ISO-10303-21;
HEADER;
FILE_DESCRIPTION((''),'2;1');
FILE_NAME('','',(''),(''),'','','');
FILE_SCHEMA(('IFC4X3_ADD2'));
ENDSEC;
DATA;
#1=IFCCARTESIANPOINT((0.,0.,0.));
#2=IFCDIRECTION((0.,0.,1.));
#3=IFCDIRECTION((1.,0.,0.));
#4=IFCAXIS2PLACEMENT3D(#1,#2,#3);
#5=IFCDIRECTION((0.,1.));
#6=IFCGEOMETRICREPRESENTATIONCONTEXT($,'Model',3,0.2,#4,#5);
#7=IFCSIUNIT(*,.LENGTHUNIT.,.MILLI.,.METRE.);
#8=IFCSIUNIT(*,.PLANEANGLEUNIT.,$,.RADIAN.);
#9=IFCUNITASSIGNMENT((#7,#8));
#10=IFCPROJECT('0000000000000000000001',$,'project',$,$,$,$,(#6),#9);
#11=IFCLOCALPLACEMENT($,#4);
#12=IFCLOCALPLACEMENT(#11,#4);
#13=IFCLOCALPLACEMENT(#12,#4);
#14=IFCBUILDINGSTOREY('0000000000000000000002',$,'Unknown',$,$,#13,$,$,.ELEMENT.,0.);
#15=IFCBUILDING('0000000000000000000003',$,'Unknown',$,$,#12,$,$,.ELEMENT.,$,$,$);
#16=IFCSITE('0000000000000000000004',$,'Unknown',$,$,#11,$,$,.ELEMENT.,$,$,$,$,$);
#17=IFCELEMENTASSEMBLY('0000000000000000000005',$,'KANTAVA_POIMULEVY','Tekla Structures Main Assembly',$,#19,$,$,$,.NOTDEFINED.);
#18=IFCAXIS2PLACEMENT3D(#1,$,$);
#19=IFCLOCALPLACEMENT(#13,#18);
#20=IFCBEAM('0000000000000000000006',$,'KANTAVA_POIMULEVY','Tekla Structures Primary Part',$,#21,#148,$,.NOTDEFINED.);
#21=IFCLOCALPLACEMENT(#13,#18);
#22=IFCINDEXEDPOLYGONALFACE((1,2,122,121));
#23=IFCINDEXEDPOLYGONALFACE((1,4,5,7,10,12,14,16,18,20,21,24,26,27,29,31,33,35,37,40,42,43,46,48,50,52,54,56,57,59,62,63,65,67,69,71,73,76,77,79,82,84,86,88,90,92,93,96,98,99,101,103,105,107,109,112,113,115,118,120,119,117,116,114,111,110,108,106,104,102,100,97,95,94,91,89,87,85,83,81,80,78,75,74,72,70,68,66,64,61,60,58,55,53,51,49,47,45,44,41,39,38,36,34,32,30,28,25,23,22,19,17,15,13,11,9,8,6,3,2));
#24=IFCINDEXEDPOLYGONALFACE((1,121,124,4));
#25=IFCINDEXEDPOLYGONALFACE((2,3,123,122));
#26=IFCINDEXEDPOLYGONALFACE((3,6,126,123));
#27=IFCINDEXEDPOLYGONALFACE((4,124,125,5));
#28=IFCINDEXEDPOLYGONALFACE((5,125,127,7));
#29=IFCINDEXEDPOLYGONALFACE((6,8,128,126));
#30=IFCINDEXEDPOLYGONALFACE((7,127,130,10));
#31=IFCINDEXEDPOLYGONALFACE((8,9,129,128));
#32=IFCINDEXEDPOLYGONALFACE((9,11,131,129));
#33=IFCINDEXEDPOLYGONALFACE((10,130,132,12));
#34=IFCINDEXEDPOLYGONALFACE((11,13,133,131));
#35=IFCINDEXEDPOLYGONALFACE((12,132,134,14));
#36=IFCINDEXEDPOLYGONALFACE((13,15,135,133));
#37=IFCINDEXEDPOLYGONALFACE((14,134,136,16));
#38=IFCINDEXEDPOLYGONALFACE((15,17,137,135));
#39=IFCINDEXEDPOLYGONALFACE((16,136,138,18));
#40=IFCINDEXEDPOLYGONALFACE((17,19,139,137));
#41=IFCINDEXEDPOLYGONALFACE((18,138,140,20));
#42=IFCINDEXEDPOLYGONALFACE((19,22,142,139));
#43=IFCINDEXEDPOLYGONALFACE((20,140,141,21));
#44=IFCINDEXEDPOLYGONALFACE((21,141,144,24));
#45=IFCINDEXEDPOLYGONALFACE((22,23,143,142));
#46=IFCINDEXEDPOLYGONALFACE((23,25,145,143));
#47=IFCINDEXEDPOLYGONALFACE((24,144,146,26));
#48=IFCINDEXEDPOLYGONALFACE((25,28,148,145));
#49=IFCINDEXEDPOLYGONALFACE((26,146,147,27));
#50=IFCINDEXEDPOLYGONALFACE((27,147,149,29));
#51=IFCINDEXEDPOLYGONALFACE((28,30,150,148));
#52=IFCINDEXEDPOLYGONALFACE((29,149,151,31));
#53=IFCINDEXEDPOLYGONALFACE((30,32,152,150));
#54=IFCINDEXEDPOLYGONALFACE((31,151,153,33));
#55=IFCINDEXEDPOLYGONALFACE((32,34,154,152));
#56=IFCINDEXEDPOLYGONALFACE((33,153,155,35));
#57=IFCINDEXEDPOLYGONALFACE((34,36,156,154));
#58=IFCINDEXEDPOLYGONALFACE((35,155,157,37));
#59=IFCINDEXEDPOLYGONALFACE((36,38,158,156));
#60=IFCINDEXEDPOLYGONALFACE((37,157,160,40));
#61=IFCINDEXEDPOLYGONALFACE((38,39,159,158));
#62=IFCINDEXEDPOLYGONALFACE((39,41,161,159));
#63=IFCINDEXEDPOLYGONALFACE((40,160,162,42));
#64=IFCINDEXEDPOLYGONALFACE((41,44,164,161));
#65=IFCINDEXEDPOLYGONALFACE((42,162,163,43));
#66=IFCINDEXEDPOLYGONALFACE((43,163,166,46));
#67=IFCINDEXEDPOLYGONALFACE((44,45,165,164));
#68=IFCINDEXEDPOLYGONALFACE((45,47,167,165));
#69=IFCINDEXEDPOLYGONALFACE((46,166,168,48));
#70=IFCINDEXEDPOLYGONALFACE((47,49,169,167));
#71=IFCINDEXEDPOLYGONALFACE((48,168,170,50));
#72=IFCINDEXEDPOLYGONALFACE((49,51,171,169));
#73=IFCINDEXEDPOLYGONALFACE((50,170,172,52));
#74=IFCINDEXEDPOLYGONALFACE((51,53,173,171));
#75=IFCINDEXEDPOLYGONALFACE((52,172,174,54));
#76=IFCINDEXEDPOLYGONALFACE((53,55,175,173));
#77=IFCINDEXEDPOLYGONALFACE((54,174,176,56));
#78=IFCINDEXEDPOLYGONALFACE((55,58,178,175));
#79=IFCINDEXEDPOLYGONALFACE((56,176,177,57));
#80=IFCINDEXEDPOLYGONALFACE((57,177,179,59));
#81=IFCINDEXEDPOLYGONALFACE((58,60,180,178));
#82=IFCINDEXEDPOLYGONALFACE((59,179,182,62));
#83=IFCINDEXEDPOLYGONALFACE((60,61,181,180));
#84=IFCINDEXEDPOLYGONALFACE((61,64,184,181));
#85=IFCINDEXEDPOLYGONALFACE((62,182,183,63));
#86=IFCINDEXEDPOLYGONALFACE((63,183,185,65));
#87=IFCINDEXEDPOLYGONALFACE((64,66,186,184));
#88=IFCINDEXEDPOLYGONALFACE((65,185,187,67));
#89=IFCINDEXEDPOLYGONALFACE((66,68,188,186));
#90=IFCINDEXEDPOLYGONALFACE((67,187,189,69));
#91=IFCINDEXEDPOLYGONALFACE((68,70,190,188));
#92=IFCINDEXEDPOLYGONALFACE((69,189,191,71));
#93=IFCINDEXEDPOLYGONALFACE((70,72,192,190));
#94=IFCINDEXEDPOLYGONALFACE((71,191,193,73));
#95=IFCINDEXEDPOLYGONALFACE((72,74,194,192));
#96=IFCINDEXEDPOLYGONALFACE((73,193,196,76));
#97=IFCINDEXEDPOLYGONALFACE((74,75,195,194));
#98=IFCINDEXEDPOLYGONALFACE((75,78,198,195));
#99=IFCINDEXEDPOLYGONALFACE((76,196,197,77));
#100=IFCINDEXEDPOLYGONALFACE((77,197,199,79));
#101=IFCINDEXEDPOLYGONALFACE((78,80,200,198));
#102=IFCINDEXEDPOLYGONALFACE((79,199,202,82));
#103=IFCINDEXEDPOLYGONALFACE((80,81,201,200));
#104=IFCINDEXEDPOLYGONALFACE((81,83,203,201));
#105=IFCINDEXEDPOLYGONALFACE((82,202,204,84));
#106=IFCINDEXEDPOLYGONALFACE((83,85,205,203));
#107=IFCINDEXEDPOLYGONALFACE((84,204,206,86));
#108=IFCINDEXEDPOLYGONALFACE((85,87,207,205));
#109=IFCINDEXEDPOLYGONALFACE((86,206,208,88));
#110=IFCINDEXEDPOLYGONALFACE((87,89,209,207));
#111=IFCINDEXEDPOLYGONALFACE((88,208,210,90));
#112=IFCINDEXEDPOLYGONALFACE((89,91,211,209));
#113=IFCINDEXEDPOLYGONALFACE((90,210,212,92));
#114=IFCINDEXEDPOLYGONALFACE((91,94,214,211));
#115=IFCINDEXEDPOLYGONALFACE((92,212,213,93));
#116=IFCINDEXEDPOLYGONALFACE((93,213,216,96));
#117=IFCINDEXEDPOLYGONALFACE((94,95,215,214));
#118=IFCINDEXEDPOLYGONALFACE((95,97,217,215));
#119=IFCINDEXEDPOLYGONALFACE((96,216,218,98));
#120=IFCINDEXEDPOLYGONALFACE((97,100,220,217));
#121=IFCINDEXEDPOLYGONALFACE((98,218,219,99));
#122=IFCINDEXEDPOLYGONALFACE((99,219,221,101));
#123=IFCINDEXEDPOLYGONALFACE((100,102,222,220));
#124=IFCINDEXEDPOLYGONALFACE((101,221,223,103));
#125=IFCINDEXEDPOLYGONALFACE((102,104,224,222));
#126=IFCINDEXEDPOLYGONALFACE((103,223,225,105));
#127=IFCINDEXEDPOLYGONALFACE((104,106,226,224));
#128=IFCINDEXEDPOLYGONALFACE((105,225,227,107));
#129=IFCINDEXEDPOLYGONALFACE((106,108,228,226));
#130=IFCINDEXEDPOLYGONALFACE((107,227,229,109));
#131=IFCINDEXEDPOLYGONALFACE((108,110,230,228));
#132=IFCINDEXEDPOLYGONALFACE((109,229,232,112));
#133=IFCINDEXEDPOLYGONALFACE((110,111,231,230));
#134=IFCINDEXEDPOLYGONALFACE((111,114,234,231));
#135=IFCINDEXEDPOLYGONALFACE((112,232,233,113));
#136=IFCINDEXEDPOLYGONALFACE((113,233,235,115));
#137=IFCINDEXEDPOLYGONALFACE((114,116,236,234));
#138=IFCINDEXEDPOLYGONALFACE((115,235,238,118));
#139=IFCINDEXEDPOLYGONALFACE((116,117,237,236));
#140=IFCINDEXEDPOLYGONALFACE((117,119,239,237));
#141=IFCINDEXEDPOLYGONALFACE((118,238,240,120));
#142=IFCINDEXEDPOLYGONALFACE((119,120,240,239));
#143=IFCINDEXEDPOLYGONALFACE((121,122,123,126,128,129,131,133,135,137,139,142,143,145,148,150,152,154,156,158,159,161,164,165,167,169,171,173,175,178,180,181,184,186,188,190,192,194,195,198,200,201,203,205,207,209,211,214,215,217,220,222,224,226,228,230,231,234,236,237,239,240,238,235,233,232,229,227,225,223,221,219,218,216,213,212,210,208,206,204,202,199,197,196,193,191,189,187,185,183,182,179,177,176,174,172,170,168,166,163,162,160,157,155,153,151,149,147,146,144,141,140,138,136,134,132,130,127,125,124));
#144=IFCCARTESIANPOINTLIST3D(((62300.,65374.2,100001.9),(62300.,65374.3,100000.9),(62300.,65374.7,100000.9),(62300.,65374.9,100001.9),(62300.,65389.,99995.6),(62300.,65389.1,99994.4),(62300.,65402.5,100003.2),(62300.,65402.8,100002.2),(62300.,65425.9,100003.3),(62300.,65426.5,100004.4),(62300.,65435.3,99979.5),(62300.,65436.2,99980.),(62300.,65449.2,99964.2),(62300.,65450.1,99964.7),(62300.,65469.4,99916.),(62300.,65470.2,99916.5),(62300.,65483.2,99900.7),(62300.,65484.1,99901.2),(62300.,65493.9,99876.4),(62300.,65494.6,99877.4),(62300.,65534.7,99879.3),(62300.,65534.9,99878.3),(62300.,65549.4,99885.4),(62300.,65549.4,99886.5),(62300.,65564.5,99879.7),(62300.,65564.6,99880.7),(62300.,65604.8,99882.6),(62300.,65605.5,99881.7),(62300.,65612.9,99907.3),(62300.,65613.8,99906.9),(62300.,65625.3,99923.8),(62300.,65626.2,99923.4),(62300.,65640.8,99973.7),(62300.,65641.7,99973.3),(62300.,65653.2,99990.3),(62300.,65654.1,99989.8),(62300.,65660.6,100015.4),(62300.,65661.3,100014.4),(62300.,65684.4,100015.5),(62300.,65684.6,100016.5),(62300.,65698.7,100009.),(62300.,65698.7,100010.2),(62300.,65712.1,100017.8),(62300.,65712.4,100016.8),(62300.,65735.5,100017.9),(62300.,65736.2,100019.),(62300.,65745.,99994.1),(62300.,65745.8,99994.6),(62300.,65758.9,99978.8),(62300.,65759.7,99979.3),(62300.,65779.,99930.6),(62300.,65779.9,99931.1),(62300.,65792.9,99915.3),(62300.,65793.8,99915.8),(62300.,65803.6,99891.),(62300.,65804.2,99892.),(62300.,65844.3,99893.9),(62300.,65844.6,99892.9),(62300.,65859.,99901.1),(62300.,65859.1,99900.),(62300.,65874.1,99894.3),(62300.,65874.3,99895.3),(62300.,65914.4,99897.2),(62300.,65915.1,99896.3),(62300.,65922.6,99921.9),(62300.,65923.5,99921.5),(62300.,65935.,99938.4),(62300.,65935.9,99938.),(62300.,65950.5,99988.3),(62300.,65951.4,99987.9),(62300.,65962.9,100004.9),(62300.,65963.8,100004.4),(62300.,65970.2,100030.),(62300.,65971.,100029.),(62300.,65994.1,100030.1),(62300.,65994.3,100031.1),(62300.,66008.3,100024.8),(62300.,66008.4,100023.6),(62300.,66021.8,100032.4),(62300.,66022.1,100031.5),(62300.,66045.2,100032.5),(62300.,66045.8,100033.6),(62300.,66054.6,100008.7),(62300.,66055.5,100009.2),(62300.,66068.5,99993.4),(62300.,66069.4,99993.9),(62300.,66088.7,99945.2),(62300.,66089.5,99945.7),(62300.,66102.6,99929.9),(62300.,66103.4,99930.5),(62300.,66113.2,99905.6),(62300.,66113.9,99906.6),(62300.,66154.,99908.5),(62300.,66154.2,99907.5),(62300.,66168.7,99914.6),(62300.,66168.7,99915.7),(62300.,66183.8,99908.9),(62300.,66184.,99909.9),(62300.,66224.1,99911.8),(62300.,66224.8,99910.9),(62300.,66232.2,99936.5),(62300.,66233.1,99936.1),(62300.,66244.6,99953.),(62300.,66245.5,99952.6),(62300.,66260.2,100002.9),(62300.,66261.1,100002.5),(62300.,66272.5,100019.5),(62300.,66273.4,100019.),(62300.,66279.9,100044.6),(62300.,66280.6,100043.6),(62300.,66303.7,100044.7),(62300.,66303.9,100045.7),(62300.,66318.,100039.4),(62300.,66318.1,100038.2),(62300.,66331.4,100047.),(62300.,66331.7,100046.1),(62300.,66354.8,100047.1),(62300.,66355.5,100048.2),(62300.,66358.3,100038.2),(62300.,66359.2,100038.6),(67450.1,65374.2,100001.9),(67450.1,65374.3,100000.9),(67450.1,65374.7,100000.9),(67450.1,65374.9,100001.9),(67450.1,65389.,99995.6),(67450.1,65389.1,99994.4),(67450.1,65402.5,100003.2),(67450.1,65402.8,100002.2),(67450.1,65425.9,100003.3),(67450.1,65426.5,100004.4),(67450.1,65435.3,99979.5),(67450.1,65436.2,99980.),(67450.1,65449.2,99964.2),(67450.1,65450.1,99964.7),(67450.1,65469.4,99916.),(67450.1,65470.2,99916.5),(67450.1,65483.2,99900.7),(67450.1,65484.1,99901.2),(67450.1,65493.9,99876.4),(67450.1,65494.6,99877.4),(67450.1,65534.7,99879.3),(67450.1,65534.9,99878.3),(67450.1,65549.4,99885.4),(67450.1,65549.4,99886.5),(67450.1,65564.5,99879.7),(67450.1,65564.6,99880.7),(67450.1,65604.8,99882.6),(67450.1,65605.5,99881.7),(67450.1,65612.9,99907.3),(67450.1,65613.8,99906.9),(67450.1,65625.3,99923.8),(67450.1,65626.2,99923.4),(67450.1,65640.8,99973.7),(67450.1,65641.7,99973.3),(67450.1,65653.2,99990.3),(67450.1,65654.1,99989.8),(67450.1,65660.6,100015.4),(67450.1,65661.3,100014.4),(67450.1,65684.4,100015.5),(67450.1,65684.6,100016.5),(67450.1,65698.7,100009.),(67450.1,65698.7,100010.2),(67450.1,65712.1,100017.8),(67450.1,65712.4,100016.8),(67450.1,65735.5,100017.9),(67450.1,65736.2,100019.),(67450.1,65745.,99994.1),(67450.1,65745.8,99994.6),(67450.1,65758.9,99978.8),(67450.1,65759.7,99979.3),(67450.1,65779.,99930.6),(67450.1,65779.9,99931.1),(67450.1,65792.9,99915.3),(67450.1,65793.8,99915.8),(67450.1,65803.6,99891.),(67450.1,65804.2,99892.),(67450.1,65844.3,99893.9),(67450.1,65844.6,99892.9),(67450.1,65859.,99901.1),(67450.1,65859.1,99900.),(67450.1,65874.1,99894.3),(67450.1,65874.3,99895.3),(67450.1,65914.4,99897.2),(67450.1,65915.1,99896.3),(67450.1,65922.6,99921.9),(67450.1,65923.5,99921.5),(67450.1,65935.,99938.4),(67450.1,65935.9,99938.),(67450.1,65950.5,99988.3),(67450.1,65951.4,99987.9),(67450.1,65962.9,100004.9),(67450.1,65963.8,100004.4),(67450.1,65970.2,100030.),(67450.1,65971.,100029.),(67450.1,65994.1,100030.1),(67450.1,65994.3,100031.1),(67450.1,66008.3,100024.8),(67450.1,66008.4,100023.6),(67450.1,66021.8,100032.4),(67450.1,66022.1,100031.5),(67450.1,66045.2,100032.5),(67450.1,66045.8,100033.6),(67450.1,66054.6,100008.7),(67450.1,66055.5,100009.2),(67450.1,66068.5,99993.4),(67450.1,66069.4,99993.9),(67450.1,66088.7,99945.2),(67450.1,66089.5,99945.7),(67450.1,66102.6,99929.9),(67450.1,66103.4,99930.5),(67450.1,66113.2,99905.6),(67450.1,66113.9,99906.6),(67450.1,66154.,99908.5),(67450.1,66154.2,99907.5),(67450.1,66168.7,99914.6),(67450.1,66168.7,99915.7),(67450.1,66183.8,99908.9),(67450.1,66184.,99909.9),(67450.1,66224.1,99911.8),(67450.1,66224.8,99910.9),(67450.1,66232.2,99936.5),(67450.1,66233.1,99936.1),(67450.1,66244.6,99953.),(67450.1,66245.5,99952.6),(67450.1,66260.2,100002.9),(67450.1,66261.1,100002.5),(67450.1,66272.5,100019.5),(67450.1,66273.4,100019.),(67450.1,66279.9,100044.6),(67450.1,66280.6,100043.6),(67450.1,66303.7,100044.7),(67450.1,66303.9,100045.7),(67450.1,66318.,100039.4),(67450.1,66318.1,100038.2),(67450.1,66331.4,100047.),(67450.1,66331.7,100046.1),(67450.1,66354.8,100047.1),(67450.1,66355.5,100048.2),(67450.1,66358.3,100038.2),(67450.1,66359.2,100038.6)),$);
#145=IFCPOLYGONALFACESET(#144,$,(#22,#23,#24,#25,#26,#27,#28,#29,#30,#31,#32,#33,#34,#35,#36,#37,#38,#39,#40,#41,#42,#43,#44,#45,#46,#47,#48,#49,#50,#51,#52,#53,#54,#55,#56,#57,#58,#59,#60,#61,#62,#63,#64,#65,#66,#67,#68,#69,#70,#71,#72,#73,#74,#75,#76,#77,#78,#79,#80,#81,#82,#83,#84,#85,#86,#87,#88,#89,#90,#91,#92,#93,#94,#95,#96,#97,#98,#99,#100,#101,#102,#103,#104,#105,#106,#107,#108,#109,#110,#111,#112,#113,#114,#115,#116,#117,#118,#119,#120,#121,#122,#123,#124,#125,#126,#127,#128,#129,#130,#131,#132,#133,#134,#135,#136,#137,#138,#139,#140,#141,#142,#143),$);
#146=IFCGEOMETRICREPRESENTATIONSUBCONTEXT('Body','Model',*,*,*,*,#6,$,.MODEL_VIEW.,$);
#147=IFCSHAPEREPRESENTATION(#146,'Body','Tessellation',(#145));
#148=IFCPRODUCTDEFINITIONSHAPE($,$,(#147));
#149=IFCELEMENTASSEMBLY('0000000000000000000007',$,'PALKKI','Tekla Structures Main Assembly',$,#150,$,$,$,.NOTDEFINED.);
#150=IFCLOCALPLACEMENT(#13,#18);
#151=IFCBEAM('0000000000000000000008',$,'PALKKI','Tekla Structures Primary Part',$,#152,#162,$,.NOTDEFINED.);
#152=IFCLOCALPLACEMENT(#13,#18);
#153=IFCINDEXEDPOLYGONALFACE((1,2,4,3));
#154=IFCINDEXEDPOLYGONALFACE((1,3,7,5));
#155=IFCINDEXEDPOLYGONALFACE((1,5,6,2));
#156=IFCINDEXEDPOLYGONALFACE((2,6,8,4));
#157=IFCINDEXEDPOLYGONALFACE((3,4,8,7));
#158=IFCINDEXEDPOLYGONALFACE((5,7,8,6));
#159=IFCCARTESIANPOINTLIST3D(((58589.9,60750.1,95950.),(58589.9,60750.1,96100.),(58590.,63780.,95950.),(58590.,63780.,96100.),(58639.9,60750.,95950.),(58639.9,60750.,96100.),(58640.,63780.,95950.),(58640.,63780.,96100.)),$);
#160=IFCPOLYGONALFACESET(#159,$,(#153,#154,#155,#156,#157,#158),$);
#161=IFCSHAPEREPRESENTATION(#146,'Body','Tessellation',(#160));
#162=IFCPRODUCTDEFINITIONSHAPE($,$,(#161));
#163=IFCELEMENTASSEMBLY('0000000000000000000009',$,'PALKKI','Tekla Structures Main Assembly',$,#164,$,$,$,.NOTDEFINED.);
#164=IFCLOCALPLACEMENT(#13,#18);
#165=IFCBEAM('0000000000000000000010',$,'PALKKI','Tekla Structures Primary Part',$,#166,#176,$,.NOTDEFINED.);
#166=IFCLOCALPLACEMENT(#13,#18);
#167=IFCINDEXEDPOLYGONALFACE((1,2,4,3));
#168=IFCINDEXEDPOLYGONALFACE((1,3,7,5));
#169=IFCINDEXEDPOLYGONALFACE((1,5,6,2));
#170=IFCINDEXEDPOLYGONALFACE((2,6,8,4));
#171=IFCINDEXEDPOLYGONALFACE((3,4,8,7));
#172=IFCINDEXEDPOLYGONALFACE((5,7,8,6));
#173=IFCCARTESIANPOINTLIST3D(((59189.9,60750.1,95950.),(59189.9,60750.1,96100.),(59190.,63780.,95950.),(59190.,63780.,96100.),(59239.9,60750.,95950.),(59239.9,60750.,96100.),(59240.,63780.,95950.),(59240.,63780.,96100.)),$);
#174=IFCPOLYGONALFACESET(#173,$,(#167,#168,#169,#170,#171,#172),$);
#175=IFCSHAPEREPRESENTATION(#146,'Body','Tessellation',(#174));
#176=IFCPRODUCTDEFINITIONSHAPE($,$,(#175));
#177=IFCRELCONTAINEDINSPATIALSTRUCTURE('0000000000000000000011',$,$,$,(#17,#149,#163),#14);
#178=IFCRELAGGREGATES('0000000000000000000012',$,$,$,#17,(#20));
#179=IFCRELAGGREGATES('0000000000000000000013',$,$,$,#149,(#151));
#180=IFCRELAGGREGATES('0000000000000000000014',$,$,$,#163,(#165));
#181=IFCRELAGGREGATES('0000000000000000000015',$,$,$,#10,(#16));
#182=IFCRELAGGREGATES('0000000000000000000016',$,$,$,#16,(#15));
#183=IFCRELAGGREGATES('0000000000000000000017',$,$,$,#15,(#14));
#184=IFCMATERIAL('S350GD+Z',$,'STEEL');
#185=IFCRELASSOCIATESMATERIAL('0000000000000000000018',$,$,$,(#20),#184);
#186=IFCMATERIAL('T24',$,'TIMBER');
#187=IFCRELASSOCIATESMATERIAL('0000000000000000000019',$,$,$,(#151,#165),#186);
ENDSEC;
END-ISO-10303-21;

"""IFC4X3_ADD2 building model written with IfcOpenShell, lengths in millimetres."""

from ifc_helpers import new_model, si_unit, direction, frame, origin_with_axes, place, context, subcontext, project, spatial, line, indexed_curve, outline, extrude, material, element, aggregate, save


model = new_model("IFC4X3_ADD2")

# Units and contexts
model_context = context("Model", 3, precision=0.2, world=origin_with_axes(), true_north=direction((0.0, 1.0)))
body_context = subcontext(model_context, "Body", "Model", "MODEL_VIEW")
ifc_project = project(units=[si_unit("LENGTHUNIT", "METRE", prefix="MILLI"), si_unit("PLANEANGLEUNIT", "RADIAN")], contexts=[model_context])

# Site, building, storey
site_placement = place(None, origin_with_axes())
site = spatial("IfcSite", under=ifc_project, at=site_placement, Name="Unknown", CompositionType="ELEMENT")
building_placement = place(site_placement, origin_with_axes())
building = spatial("IfcBuilding", under=site, at=building_placement, Name="Unknown", CompositionType="ELEMENT")
storey_placement = place(building_placement, origin_with_axes())
storey = spatial("IfcBuildingStorey", under=building, at=storey_placement, Name="Unknown", CompositionType="ELEMENT", Elevation=0.0)

# Element assemblies, beams
ifc_material_1 = material(Name="S350GD+Z", Category="STEEL")
assembly_1_placement = place(storey_placement, frame((62300.0, 65856.3, 99959.1), z_axis=(0.0, -0.99889, -0.047106), x_axis=(1.0, 0.0, 0.0)))
assembly_1 = element("IfcElementAssembly", 1, at=assembly_1_placement, inside=storey, Name="KANTAVA_POIMULEVY", Description="Tekla Structures Main Assembly", PredefinedType="NOTDEFINED")
beam_1_placement = place(assembly_1_placement, origin_with_axes())
beam_1 = element("IfcBeam", 2, at=beam_1_placement, material=ifc_material_1, Name="KANTAVA_POIMULEVY", Description="Tekla Structures Primary Part", PredefinedType="NOTDEFINED", context=body_context, shape_type="SolidModel", body=[
    extrude(outline(indexed_curve([(479.5, 65.5), (478.8, 65.5), (465.0, 58.5), (451.2, 65.5), (427.1, 65.5), (418.6, 40.7), (405.5, 24.8), (387.6, -24.3), (374.5, -40.2), (365.1, -64.5), (325.0, -64.5), (310.0, -58.1), (295.0, -64.5), (254.8, -64.5), (245.5, -40.2), (232.4, -24.3), (214.5, 24.8), (201.4, 40.7), (192.9, 65.5), (168.8, 65.5), (155.0, 58.5), (141.2, 65.5), (117.1, 65.5), (108.6, 40.7), (95.5, 24.8), (77.6, -24.3), (64.5, -40.2), (55.1, -64.5), (15.0, -64.5), (0.0, -58.1), (-15.0, -64.5), (-55.2, -64.5), (-64.5, -40.2), (-77.6, -24.3), (-95.5, 24.8), (-108.6, 40.7), (-117.2, 65.5), (-141.2, 65.5), (-155.0, 58.5), (-168.8, 65.5), (-192.9, 65.5), (-201.4, 40.7), (-214.5, 24.8), (-232.4, -24.3), (-245.5, -40.2), (-254.9, -64.5), (-295.0, -64.5), (-310.0, -58.1), (-325.0, -64.5), (-365.2, -64.5), (-374.5, -40.2), (-387.6, -24.3), (-405.5, 24.8), (-418.6, 40.7), (-427.1, 65.5), (-451.2, 65.5), (-465.0, 58.5), (-478.8, 65.5), (-502.9, 65.5), (-506.2, 55.7), (-505.2, 55.4), (-502.1, 64.5), (-479.0, 64.5), (-465.0, 57.3), (-451.0, 64.5), (-427.9, 64.5), (-419.5, 40.2), (-406.4, 24.3), (-388.5, -24.8), (-375.4, -40.7), (-365.9, -65.5), (-324.8, -65.5), (-310.0, -59.1), (-295.2, -65.5), (-254.2, -65.5), (-244.6, -40.7), (-231.5, -24.8), (-213.6, 24.3), (-200.5, 40.2), (-192.1, 64.5), (-169.0, 64.5), (-155.0, 57.3), (-141.0, 64.5), (-117.9, 64.5), (-109.5, 40.2), (-96.4, 24.3), (-78.5, -24.8), (-65.4, -40.7), (-55.9, -65.5), (-14.8, -65.5), (0.0, -59.1), (14.8, -65.5), (55.8, -65.5), (65.4, -40.7), (78.5, -24.8), (96.4, 24.3), (109.5, 40.2), (117.8, 64.5), (141.0, 64.5), (155.0, 57.3), (169.0, 64.5), (192.1, 64.5), (200.5, 40.2), (213.6, 24.3), (231.5, -24.8), (244.6, -40.7), (254.1, -65.5), (295.2, -65.5), (310.0, -59.1), (324.8, -65.5), (365.8, -65.5), (375.4, -40.7), (388.5, -24.8), (406.4, 24.3), (419.5, 40.2), (427.9, 64.5), (451.0, 64.5), (465.0, 57.3), (479.0, 64.5), (479.5, 64.5)], segments=[line(1, 2, 3, 4, 5, 6, 7, 8, 9, 10, 11, 12, 13, 14, 15, 16, 17, 18, 19, 20, 21, 22, 23, 24, 25, 26, 27, 28, 29, 30, 31, 32, 33, 34, 35, 36, 37, 38, 39, 40, 41, 42, 43, 44, 45, 46, 47, 48, 49, 50, 51, 52, 53, 54, 55, 56, 57, 58, 59, 60, 61, 62, 63, 64, 65, 66, 67, 68, 69, 70, 71, 72, 73, 74, 75, 76, 77, 78, 79, 80, 81, 82, 83, 84, 85, 86, 87, 88, 89, 90, 91, 92, 93, 94, 95, 96, 97, 98, 99, 100, 101, 102, 103, 104, 105, 106, 107, 108, 109, 110, 111, 112, 113, 114, 115, 116, 117, 118, 119, 120, 1)])), frame((0.0, 0.0, 0.0), z_axis=(-1.0, 0.0, 0.0), x_axis=(0.0, 0.0, 1.0)), (0.0, 0.0, -1.0), 5150.1),
])
aggregate(assembly_1, [beam_1])
assembly_2_placement = place(storey_placement, frame((58615.0, 63780.0, 96025.0), z_axis=(-1.0, 0.000016, 0.0), x_axis=(-0.000016, -1.0, 0.0)))
assembly_2 = element("IfcElementAssembly", 3, at=assembly_2_placement, inside=storey, Name="PALKKI", Description="Tekla Structures Main Assembly", PredefinedType="NOTDEFINED")
ifc_material_2 = material(Name="T24", Category="TIMBER")
beam_2_placement = place(assembly_2_placement, origin_with_axes())
beam_2 = element("IfcBeam", 4, at=beam_2_placement, material=ifc_material_2, Name="PALKKI", Description="Tekla Structures Primary Part", PredefinedType="NOTDEFINED", context=body_context, shape_type="SolidModel", body=[
    extrude(outline(indexed_curve([(-25.0, -75.0), (25.0, -75.0), (25.0, 75.0), (-25.0, 75.0)], segments=[line(1, 2, 3, 4, 1)])), frame((0.0, 0.0, 0.0), z_axis=(-1.0, 0.0, 0.0), x_axis=(0.0, 0.0, 1.0)), (0.0, 0.0, -1.0), 3029.9),
])
aggregate(assembly_2, [beam_2])
assembly_3_placement = place(storey_placement, frame((59215.0, 63780.0, 96025.0), z_axis=(-1.0, 0.000016, 0.0), x_axis=(-0.000016, -1.0, 0.0)))
assembly_3 = element("IfcElementAssembly", 5, at=assembly_3_placement, inside=storey, Name="PALKKI", Description="Tekla Structures Main Assembly", PredefinedType="NOTDEFINED")
beam_3_placement = place(assembly_3_placement, origin_with_axes())
beam_3 = element("IfcBeam", 6, at=beam_3_placement, material=ifc_material_2, Name="PALKKI", Description="Tekla Structures Primary Part", PredefinedType="NOTDEFINED", context=body_context, shape_type="SolidModel", body=[
    extrude(outline(indexed_curve([(-25.0, -75.0), (25.0, -75.0), (25.0, 75.0), (-25.0, 75.0)], segments=[line(1, 2, 3, 4, 1)])), frame((0.0, 0.0, 0.0), z_axis=(-1.0, 0.0, 0.0), x_axis=(0.0, 0.0, 1.0)), (0.0, 0.0, -1.0), 3029.9),
])
aggregate(assembly_3, [beam_3])

save(model, "model.ifc")
